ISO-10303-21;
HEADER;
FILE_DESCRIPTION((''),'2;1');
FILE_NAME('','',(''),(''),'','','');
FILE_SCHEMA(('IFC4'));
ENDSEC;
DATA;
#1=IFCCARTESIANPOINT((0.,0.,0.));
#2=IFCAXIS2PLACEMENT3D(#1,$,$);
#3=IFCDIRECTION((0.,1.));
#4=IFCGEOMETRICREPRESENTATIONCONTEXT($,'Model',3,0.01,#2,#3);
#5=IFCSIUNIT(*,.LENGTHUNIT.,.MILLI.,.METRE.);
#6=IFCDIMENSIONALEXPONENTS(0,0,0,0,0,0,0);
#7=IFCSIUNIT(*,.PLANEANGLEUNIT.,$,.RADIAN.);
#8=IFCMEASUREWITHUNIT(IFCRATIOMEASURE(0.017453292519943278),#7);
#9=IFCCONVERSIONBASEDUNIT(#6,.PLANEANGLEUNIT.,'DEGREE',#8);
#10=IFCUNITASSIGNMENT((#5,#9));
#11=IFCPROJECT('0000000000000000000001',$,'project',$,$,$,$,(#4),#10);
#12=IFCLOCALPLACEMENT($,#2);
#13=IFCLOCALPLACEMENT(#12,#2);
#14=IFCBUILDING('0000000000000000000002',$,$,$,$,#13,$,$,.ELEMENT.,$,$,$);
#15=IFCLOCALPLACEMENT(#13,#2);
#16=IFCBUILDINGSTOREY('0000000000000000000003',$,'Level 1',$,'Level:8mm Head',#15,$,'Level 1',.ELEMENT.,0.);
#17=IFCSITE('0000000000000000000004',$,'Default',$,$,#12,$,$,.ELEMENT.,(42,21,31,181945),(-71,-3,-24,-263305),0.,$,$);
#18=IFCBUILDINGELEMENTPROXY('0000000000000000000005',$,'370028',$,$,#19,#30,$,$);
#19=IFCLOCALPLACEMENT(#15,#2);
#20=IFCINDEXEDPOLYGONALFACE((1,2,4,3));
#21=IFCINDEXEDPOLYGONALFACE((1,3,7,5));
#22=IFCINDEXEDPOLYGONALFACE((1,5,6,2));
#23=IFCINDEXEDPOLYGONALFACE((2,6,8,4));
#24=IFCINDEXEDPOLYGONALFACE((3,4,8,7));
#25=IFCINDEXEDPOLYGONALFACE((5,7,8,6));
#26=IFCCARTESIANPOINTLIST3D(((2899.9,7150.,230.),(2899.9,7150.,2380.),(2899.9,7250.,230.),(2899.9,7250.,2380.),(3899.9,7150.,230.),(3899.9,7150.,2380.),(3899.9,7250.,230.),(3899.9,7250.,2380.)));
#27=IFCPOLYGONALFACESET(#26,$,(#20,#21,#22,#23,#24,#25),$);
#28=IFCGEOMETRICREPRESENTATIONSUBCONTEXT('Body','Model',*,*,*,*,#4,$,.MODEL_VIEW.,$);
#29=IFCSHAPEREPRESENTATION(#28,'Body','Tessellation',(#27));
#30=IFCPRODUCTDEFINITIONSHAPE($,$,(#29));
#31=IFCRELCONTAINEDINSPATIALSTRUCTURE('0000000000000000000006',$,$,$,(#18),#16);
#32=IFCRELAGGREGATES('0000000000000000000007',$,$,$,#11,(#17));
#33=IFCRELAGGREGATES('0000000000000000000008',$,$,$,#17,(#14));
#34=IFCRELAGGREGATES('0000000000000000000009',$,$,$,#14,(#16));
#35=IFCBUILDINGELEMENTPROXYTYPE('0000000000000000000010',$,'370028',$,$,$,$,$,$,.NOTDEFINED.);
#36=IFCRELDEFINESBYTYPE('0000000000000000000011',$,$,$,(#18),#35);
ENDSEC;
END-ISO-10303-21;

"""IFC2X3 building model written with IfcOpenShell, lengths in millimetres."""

from ifc_helpers import new_model, entity, si_unit, converted_unit, direction, frame, frame_2d, origin, place, context, subcontext, project, spatial, rectangle, extrude, type_object, element, save


model = new_model("IFC2X3")

# Units and contexts
model_context = context("Model", 3, precision=0.01, world=origin(), true_north=direction((0.0, 1.0)))
body_context = subcontext(model_context, "Body", "Model", "MODEL_VIEW")
ifc_project = project(units=[si_unit("LENGTHUNIT", "METRE", prefix="MILLI"), converted_unit("PLANEANGLEUNIT", "DEGREE", entity("IfcRatioMeasure", 0.017453292519943278), si_unit("PLANEANGLEUNIT", "RADIAN"), dimensions=[0, 0, 0, 0, 0, 0, 0])], contexts=[model_context])

# Site, building, storey
site_placement = place(None, origin())
site = spatial("IfcSite", under=ifc_project, at=site_placement, Name="Default", CompositionType="ELEMENT", RefLatitude=(42, 21, 31, 181945), RefLongitude=(-71, -3, -24, -263305), RefElevation=0.0)
building_placement = place(site_placement, origin())
building = spatial("IfcBuilding", under=site, at=building_placement, CompositionType="ELEMENT")
storey_placement = place(building_placement, origin())
storey = spatial("IfcBuildingStorey", under=building, at=storey_placement, Name="Level 1", ObjectType="Level:8mm Head", LongName="Level 1", CompositionType="ELEMENT", Elevation=0.0)

# Building element proxy
building_element_proxy_type_1 = type_object("IfcBuildingElementProxyType", Name="370028", PredefinedType="NOTDEFINED")
proxy_1_placement = place(storey_placement, origin())
element("IfcBuildingElementProxy", 1, at=proxy_1_placement, inside=storey, type_object=building_element_proxy_type_1, Name="370028", context=body_context, shape_type="SweptSolid", body=[
    extrude(rectangle(XDim=1000.0, YDim=100.0, at=frame_2d((0.0, 0.0), x_axis=(1.0, 0.0))), frame((3399.9, 7200.0, 230.0)), (0.0, 0.0, 1.0), 2150.0),
])

save(model, "model.ifc")
